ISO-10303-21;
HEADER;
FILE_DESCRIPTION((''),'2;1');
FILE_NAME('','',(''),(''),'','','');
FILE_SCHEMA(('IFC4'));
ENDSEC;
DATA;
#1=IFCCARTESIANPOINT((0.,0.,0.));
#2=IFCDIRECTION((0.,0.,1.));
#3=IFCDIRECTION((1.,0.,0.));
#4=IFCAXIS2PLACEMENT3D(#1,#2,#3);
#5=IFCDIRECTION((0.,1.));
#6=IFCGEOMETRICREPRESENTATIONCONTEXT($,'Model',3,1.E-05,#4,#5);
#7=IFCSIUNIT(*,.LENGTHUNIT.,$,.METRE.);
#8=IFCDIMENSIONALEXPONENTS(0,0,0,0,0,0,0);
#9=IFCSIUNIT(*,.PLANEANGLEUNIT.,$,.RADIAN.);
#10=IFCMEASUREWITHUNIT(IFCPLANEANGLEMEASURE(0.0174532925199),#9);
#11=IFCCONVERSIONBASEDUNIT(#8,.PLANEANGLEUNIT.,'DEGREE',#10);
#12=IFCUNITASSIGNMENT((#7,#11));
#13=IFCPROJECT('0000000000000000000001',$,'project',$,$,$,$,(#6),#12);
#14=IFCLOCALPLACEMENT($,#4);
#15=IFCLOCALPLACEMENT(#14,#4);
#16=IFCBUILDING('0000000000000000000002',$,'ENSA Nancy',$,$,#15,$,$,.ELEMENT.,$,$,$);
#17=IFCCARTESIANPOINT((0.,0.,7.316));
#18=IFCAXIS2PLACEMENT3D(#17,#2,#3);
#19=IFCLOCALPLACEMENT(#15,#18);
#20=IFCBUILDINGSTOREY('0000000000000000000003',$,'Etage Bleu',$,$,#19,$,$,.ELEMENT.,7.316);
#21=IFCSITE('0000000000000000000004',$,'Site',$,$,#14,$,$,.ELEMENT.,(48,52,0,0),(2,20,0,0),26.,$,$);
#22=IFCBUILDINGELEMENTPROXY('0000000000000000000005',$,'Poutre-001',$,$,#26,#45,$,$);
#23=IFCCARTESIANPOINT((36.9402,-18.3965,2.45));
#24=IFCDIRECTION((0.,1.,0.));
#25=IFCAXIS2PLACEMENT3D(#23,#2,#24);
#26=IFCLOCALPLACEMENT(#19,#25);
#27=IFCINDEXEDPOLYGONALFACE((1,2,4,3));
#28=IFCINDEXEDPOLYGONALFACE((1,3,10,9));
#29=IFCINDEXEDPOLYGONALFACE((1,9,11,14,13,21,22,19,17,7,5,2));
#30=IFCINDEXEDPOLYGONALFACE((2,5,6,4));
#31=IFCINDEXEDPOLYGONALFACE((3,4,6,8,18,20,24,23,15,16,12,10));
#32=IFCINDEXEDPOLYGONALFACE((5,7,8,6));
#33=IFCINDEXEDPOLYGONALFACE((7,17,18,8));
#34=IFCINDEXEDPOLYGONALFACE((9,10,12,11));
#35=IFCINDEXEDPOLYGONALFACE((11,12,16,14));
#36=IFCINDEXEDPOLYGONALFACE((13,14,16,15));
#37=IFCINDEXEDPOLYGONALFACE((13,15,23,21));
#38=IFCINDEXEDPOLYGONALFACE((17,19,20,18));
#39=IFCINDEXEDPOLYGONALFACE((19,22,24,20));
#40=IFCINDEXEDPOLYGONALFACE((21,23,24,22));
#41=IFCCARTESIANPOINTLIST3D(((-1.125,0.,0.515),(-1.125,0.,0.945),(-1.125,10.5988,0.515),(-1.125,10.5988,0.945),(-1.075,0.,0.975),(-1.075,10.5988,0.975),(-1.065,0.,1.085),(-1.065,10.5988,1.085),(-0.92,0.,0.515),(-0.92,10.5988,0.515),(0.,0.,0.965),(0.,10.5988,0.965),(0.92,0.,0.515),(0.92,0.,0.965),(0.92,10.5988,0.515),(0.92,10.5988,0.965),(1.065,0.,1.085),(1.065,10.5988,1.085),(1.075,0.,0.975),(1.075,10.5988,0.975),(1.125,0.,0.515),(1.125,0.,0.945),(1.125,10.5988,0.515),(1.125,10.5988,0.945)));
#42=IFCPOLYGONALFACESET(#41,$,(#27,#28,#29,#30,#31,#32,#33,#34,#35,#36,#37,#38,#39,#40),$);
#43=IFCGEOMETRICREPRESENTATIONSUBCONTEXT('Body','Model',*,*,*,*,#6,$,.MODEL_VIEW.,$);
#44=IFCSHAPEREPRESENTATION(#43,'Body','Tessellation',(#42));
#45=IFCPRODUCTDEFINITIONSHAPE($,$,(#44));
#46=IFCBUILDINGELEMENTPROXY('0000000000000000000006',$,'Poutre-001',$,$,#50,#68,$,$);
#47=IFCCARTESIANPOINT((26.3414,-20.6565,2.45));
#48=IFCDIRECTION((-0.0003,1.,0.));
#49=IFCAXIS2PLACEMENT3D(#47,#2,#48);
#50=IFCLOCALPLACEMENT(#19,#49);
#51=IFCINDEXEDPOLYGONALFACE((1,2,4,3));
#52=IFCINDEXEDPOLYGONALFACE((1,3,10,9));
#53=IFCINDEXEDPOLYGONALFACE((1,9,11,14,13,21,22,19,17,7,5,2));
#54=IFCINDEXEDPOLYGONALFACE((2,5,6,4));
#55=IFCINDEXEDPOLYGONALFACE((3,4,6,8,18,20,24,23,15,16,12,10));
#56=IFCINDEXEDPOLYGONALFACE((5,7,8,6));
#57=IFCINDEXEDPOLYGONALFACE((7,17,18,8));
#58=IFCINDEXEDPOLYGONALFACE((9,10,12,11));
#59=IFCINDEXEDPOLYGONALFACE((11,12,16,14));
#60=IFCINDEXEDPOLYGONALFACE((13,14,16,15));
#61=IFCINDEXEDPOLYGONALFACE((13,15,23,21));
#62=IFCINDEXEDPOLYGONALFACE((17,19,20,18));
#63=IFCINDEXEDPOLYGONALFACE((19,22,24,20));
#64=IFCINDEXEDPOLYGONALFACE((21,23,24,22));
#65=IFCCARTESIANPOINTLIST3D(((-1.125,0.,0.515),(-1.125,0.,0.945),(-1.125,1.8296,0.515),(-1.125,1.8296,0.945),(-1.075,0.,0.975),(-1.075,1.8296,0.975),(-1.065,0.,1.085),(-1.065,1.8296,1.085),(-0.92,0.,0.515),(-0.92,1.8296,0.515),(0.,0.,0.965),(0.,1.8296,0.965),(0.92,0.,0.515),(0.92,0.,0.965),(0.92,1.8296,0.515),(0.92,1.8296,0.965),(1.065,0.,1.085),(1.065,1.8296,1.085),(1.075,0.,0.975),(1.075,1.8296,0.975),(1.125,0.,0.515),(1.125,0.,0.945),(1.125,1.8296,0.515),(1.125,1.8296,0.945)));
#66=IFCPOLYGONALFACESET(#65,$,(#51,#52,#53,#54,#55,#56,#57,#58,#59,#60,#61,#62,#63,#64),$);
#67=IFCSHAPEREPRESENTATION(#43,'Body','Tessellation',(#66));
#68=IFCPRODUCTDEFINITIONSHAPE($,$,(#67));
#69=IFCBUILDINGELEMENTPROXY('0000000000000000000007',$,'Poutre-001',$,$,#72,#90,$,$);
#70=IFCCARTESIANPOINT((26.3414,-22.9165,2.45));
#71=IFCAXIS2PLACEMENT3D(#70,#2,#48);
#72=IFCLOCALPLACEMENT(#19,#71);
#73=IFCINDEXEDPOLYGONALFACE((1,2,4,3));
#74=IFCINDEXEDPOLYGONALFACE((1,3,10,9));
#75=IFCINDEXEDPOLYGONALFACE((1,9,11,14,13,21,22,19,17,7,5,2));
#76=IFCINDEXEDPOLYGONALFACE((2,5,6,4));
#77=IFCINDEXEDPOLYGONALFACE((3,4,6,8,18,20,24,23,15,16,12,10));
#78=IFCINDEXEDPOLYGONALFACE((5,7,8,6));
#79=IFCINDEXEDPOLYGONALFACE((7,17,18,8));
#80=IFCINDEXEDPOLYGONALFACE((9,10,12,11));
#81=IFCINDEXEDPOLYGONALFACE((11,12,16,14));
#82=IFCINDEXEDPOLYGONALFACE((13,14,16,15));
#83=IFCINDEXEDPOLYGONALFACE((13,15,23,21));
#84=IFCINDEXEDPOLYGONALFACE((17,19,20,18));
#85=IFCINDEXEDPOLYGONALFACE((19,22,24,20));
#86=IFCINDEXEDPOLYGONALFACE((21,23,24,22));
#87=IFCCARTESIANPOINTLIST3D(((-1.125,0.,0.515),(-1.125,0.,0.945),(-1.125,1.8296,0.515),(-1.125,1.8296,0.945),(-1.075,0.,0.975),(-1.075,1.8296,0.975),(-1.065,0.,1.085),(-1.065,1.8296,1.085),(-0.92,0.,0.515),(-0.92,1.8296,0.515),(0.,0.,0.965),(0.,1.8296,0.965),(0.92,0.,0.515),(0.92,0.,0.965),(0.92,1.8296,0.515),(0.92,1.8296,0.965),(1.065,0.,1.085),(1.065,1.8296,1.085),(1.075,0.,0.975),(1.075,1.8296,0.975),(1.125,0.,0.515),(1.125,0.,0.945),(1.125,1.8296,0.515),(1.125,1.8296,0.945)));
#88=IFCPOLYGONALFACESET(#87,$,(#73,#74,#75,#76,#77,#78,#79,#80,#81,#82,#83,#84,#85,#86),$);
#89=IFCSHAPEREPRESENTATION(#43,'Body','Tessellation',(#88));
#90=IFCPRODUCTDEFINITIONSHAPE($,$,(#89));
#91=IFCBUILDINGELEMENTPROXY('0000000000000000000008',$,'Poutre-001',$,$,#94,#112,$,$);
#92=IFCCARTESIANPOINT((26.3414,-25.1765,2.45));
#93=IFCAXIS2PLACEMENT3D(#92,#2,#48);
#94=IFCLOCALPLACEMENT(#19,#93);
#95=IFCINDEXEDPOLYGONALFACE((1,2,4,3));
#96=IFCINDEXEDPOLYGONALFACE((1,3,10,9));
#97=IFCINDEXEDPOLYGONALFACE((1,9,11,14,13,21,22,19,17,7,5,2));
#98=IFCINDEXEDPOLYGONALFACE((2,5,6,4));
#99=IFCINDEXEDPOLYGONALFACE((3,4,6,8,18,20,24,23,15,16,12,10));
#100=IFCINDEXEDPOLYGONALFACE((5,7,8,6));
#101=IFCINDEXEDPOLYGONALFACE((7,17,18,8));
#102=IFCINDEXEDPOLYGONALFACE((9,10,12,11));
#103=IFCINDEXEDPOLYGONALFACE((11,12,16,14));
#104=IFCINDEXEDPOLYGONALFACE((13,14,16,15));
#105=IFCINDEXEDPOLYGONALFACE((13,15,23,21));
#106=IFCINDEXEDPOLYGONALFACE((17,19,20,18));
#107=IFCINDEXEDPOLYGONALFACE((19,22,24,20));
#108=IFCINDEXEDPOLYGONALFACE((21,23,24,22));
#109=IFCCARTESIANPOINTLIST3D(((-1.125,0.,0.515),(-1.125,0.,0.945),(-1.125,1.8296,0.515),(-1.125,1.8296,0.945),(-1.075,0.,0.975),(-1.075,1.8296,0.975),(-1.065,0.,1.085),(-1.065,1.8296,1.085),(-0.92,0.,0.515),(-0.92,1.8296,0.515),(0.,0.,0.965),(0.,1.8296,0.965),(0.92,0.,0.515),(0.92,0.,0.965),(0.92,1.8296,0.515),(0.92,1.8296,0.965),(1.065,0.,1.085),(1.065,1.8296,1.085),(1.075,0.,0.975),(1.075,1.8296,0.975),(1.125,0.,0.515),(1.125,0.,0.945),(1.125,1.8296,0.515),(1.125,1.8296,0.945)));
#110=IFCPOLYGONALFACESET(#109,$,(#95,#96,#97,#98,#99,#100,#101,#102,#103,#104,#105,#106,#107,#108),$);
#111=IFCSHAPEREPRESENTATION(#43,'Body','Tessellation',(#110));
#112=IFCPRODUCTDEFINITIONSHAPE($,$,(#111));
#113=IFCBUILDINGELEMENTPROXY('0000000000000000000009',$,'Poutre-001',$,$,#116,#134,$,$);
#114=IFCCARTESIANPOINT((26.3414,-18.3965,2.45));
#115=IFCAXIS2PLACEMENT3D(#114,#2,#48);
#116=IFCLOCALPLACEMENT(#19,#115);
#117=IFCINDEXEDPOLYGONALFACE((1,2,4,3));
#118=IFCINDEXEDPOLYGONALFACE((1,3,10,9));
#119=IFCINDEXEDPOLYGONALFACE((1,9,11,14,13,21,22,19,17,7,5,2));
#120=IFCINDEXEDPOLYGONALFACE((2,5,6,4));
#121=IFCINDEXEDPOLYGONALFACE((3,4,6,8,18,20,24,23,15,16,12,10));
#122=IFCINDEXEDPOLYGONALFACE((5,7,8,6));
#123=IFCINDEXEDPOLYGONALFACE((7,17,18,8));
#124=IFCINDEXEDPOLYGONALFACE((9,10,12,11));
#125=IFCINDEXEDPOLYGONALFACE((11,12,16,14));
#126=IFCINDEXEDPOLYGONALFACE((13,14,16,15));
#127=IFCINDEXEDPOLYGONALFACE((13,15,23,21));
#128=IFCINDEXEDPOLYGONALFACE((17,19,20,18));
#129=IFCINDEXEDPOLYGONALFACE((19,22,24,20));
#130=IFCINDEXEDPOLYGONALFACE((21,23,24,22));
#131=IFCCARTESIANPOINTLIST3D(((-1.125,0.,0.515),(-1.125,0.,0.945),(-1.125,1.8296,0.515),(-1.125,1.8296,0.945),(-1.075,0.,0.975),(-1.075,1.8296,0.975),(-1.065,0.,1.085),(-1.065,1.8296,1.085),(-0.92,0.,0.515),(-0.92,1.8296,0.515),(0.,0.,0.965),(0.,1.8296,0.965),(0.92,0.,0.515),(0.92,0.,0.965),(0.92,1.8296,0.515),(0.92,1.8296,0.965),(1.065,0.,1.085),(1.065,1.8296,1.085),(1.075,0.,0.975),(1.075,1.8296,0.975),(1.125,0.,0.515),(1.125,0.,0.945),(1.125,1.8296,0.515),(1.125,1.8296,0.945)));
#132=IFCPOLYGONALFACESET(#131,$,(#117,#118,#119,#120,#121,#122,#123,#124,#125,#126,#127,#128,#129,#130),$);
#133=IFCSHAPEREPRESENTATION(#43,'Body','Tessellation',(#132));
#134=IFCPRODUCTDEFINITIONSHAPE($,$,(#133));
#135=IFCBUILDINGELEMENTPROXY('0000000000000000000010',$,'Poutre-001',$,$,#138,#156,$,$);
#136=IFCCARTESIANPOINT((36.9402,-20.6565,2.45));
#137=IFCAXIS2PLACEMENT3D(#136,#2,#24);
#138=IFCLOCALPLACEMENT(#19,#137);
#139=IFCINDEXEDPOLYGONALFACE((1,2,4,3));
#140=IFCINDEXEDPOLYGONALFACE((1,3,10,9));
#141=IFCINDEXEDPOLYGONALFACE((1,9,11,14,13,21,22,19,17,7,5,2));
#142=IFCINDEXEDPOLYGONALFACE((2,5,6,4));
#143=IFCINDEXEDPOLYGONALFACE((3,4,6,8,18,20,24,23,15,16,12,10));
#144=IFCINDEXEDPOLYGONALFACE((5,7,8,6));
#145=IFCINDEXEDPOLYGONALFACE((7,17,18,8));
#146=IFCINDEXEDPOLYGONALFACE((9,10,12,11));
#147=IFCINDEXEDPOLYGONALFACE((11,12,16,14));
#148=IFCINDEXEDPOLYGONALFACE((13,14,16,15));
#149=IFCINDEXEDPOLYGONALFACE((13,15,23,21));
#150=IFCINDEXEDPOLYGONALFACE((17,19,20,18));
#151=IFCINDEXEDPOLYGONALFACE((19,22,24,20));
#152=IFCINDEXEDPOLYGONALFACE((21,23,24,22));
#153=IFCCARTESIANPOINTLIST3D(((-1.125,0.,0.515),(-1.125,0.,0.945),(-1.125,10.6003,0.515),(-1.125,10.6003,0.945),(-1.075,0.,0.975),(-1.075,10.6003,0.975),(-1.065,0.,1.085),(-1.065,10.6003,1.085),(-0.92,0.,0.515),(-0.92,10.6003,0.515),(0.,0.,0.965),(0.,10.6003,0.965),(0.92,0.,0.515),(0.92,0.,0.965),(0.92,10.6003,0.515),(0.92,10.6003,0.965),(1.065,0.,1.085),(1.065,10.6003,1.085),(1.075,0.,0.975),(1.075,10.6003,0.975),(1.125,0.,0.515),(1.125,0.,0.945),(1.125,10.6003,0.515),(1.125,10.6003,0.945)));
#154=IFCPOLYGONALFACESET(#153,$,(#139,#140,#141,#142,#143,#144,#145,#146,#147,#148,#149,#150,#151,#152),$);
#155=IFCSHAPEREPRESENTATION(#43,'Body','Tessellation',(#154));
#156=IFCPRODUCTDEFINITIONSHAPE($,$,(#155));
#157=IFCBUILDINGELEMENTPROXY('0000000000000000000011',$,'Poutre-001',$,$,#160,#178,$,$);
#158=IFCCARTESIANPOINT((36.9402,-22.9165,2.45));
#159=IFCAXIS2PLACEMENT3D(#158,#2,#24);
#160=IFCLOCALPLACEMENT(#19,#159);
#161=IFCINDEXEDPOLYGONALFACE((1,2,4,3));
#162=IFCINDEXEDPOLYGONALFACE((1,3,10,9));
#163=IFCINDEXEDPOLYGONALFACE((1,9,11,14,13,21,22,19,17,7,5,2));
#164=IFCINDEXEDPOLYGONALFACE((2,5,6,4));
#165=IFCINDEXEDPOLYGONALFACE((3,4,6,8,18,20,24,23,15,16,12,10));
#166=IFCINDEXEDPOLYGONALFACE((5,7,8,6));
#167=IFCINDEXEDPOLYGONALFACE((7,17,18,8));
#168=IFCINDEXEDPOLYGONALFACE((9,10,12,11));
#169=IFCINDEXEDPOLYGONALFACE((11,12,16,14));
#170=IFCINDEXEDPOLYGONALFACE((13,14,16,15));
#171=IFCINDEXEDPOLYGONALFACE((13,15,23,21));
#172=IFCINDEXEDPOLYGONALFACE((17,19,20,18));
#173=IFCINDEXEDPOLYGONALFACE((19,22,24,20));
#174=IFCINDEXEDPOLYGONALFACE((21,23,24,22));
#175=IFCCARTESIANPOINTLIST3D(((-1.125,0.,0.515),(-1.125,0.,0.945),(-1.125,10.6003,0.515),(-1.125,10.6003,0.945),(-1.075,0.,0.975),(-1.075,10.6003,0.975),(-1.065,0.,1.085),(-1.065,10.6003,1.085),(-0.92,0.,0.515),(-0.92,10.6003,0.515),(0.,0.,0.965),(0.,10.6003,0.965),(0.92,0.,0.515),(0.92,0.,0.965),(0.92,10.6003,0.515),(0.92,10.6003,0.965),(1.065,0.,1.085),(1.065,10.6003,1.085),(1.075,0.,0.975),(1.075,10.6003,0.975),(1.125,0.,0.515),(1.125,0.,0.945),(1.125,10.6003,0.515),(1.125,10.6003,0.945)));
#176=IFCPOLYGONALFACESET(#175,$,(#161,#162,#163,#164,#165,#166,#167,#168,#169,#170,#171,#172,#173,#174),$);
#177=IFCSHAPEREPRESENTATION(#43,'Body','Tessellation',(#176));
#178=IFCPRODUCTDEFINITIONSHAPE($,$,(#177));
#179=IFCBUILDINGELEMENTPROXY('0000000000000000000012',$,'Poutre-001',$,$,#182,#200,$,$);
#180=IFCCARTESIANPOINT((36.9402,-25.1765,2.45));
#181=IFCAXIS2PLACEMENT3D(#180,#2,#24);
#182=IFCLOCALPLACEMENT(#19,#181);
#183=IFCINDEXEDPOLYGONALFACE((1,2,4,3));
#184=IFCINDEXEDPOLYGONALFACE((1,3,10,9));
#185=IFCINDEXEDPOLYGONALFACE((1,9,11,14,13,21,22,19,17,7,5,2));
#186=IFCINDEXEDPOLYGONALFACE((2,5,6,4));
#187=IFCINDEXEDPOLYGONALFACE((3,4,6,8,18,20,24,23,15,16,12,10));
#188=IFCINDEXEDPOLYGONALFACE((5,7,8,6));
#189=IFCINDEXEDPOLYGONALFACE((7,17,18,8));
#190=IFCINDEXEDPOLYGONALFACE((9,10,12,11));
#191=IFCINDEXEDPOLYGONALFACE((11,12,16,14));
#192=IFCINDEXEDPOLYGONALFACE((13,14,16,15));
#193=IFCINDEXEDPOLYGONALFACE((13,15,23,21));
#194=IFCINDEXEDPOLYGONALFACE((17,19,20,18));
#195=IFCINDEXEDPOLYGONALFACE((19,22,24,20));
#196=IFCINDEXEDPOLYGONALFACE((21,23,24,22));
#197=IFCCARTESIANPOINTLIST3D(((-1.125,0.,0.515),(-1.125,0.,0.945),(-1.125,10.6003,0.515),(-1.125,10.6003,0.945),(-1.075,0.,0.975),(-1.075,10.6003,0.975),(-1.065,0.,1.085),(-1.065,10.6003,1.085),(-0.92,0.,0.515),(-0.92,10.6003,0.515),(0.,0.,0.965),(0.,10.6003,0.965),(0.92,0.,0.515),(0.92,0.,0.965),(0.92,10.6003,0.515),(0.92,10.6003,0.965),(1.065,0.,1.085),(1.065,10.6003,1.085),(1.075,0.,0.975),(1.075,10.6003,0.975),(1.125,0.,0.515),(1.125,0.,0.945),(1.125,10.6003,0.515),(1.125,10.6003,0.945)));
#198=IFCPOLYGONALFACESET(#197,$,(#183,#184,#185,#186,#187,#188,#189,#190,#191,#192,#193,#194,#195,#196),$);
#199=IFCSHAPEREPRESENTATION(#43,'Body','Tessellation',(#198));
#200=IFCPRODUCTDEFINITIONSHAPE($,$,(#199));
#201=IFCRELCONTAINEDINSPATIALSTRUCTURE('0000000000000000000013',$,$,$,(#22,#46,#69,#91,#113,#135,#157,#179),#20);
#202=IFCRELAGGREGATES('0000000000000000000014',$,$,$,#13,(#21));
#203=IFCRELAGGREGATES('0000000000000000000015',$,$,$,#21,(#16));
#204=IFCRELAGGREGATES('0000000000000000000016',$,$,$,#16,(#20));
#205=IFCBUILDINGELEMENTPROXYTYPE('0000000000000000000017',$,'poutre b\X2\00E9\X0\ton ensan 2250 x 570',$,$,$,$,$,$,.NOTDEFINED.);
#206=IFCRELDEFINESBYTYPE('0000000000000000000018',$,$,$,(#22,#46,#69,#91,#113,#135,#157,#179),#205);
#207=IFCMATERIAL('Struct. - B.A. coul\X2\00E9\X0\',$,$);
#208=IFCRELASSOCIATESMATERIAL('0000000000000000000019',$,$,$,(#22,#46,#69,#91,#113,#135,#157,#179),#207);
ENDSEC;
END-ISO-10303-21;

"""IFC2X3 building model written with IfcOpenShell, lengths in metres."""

from ifc_helpers import new_model, entity, si_unit, converted_unit, direction, frame, origin_with_axes, place, context, subcontext, project, spatial, polyline, outline, extrude, material, type_object, element, save


model = new_model("IFC2X3")

# Units and contexts
model_context = context("Model", 3, precision=1e-05, world=origin_with_axes(), true_north=direction((0.0, 1.0)))
body_context = subcontext(model_context, "Body", "Model", "MODEL_VIEW")
ifc_project = project(units=[si_unit("LENGTHUNIT", "METRE"), converted_unit("PLANEANGLEUNIT", "DEGREE", entity("IfcPlaneAngleMeasure", 0.0174532925199), si_unit("PLANEANGLEUNIT", "RADIAN"), dimensions=[0, 0, 0, 0, 0, 0, 0])], contexts=[model_context])

# Site, building, storey
site_placement = place(None, origin_with_axes())
site = spatial("IfcSite", under=ifc_project, at=site_placement, Name="Site", CompositionType="ELEMENT", RefLatitude=(48, 52, 0, 0), RefLongitude=(2, 20, 0, 0), RefElevation=26.0)
building_placement = place(site_placement, origin_with_axes())
building = spatial("IfcBuilding", under=site, at=building_placement, Name="ENSA Nancy", CompositionType="ELEMENT")
storey_placement = place(building_placement, frame((0.0, 0.0, 7.316), z_axis=(0.0, 0.0, 1.0), x_axis=(1.0, 0.0, 0.0)))
storey = spatial("IfcBuildingStorey", under=building, at=storey_placement, Name="Etage Bleu", CompositionType="ELEMENT", Elevation=7.316)

# Building element proxies
ifc_material_1 = material(Name="Struct. - B.A. coulé")
building_element_proxy_type_1 = type_object("IfcBuildingElementProxyType", Name="poutre béton ensan 2250 x 570", PredefinedType="NOTDEFINED")
proxy_1_placement = place(storey_placement, frame((36.9402, -18.3965, 2.45), z_axis=(0.0, 0.0, 1.0), x_axis=(0.0, 1.0, 0.0)))
element("IfcBuildingElementProxy", 1, at=proxy_1_placement, inside=storey, type_object=building_element_proxy_type_1, material=ifc_material_1, Name="Poutre-001", context=body_context, shape_type="SweptSolid", body=[
    extrude(outline(polyline([(-1.065, 1.085), (-1.075, 0.975), (-1.125, 0.945), (-1.125, 0.515), (-0.92, 0.515), (0.0, 0.965), (0.92, 0.965), (0.92, 0.515), (1.125, 0.515), (1.125, 0.945), (1.075, 0.975), (1.065, 1.085), (-1.065, 1.085)])), frame((0.0, 10.5988, 0.0), z_axis=(0.0, -1.0, 0.0), x_axis=(1.0, 0.0, 0.0)), (0.0, 0.0, 1.0), 10.5988),
])
for number, where, z_axis, x_axis, name in (
    (2, (26.3414, -20.6565, 2.45), (0.0, 0.0, 1.0), (-0.0003, 1.0, 0.0), "Poutre-001"),
    (3, (26.3414, -22.9165, 2.45), (0.0, 0.0, 1.0), (-0.0003, 1.0, 0.0), "Poutre-001"),
    (4, (26.3414, -25.1765, 2.45), (0.0, 0.0, 1.0), (-0.0003, 1.0, 0.0), "Poutre-001"),
    (5, (26.3414, -18.3965, 2.45), (0.0, 0.0, 1.0), (-0.0003, 1.0, 0.0), "Poutre-001"),
):
    element("IfcBuildingElementProxy", number, at=place(storey_placement, frame(where, z_axis=z_axis, x_axis=x_axis)), inside=storey, type_object=building_element_proxy_type_1, material=ifc_material_1, Name=name, context=body_context, shape_type="SweptSolid", body=[
        extrude(outline(polyline([(-1.065, 1.085), (-1.075, 0.975), (-1.125, 0.945), (-1.125, 0.515), (-0.92, 0.515), (0.0, 0.965), (0.92, 0.965), (0.92, 0.515), (1.125, 0.515), (1.125, 0.945), (1.075, 0.975), (1.065, 1.085), (-1.065, 1.085)])), frame((0.0, 1.8296, 0.0), z_axis=(0.0, -1.0, 0.0), x_axis=(1.0, 0.0, 0.0)), (0.0, 0.0, 1.0), 1.8296),
    ])
for number, where, z_axis, x_axis, name in (
    (6, (36.9402, -20.6565, 2.45), (0.0, 0.0, 1.0), (0.0, 1.0, 0.0), "Poutre-001"),
    (7, (36.9402, -22.9165, 2.45), (0.0, 0.0, 1.0), (0.0, 1.0, 0.0), "Poutre-001"),
    (8, (36.9402, -25.1765, 2.45), (0.0, 0.0, 1.0), (0.0, 1.0, 0.0), "Poutre-001"),
):
    element("IfcBuildingElementProxy", number, at=place(storey_placement, frame(where, z_axis=z_axis, x_axis=x_axis)), inside=storey, type_object=building_element_proxy_type_1, material=ifc_material_1, Name=name, context=body_context, shape_type="SweptSolid", body=[
        extrude(outline(polyline([(-1.065, 1.085), (-1.075, 0.975), (-1.125, 0.945), (-1.125, 0.515), (-0.92, 0.515), (0.0, 0.965), (0.92, 0.965), (0.92, 0.515), (1.125, 0.515), (1.125, 0.945), (1.075, 0.975), (1.065, 1.085), (-1.065, 1.085)])), frame((0.0, 10.6003, 0.0), z_axis=(0.0, -1.0, 0.0), x_axis=(1.0, 0.0, 0.0)), (0.0, 0.0, 1.0), 10.6003),
    ])

save(model, "model.ifc")
